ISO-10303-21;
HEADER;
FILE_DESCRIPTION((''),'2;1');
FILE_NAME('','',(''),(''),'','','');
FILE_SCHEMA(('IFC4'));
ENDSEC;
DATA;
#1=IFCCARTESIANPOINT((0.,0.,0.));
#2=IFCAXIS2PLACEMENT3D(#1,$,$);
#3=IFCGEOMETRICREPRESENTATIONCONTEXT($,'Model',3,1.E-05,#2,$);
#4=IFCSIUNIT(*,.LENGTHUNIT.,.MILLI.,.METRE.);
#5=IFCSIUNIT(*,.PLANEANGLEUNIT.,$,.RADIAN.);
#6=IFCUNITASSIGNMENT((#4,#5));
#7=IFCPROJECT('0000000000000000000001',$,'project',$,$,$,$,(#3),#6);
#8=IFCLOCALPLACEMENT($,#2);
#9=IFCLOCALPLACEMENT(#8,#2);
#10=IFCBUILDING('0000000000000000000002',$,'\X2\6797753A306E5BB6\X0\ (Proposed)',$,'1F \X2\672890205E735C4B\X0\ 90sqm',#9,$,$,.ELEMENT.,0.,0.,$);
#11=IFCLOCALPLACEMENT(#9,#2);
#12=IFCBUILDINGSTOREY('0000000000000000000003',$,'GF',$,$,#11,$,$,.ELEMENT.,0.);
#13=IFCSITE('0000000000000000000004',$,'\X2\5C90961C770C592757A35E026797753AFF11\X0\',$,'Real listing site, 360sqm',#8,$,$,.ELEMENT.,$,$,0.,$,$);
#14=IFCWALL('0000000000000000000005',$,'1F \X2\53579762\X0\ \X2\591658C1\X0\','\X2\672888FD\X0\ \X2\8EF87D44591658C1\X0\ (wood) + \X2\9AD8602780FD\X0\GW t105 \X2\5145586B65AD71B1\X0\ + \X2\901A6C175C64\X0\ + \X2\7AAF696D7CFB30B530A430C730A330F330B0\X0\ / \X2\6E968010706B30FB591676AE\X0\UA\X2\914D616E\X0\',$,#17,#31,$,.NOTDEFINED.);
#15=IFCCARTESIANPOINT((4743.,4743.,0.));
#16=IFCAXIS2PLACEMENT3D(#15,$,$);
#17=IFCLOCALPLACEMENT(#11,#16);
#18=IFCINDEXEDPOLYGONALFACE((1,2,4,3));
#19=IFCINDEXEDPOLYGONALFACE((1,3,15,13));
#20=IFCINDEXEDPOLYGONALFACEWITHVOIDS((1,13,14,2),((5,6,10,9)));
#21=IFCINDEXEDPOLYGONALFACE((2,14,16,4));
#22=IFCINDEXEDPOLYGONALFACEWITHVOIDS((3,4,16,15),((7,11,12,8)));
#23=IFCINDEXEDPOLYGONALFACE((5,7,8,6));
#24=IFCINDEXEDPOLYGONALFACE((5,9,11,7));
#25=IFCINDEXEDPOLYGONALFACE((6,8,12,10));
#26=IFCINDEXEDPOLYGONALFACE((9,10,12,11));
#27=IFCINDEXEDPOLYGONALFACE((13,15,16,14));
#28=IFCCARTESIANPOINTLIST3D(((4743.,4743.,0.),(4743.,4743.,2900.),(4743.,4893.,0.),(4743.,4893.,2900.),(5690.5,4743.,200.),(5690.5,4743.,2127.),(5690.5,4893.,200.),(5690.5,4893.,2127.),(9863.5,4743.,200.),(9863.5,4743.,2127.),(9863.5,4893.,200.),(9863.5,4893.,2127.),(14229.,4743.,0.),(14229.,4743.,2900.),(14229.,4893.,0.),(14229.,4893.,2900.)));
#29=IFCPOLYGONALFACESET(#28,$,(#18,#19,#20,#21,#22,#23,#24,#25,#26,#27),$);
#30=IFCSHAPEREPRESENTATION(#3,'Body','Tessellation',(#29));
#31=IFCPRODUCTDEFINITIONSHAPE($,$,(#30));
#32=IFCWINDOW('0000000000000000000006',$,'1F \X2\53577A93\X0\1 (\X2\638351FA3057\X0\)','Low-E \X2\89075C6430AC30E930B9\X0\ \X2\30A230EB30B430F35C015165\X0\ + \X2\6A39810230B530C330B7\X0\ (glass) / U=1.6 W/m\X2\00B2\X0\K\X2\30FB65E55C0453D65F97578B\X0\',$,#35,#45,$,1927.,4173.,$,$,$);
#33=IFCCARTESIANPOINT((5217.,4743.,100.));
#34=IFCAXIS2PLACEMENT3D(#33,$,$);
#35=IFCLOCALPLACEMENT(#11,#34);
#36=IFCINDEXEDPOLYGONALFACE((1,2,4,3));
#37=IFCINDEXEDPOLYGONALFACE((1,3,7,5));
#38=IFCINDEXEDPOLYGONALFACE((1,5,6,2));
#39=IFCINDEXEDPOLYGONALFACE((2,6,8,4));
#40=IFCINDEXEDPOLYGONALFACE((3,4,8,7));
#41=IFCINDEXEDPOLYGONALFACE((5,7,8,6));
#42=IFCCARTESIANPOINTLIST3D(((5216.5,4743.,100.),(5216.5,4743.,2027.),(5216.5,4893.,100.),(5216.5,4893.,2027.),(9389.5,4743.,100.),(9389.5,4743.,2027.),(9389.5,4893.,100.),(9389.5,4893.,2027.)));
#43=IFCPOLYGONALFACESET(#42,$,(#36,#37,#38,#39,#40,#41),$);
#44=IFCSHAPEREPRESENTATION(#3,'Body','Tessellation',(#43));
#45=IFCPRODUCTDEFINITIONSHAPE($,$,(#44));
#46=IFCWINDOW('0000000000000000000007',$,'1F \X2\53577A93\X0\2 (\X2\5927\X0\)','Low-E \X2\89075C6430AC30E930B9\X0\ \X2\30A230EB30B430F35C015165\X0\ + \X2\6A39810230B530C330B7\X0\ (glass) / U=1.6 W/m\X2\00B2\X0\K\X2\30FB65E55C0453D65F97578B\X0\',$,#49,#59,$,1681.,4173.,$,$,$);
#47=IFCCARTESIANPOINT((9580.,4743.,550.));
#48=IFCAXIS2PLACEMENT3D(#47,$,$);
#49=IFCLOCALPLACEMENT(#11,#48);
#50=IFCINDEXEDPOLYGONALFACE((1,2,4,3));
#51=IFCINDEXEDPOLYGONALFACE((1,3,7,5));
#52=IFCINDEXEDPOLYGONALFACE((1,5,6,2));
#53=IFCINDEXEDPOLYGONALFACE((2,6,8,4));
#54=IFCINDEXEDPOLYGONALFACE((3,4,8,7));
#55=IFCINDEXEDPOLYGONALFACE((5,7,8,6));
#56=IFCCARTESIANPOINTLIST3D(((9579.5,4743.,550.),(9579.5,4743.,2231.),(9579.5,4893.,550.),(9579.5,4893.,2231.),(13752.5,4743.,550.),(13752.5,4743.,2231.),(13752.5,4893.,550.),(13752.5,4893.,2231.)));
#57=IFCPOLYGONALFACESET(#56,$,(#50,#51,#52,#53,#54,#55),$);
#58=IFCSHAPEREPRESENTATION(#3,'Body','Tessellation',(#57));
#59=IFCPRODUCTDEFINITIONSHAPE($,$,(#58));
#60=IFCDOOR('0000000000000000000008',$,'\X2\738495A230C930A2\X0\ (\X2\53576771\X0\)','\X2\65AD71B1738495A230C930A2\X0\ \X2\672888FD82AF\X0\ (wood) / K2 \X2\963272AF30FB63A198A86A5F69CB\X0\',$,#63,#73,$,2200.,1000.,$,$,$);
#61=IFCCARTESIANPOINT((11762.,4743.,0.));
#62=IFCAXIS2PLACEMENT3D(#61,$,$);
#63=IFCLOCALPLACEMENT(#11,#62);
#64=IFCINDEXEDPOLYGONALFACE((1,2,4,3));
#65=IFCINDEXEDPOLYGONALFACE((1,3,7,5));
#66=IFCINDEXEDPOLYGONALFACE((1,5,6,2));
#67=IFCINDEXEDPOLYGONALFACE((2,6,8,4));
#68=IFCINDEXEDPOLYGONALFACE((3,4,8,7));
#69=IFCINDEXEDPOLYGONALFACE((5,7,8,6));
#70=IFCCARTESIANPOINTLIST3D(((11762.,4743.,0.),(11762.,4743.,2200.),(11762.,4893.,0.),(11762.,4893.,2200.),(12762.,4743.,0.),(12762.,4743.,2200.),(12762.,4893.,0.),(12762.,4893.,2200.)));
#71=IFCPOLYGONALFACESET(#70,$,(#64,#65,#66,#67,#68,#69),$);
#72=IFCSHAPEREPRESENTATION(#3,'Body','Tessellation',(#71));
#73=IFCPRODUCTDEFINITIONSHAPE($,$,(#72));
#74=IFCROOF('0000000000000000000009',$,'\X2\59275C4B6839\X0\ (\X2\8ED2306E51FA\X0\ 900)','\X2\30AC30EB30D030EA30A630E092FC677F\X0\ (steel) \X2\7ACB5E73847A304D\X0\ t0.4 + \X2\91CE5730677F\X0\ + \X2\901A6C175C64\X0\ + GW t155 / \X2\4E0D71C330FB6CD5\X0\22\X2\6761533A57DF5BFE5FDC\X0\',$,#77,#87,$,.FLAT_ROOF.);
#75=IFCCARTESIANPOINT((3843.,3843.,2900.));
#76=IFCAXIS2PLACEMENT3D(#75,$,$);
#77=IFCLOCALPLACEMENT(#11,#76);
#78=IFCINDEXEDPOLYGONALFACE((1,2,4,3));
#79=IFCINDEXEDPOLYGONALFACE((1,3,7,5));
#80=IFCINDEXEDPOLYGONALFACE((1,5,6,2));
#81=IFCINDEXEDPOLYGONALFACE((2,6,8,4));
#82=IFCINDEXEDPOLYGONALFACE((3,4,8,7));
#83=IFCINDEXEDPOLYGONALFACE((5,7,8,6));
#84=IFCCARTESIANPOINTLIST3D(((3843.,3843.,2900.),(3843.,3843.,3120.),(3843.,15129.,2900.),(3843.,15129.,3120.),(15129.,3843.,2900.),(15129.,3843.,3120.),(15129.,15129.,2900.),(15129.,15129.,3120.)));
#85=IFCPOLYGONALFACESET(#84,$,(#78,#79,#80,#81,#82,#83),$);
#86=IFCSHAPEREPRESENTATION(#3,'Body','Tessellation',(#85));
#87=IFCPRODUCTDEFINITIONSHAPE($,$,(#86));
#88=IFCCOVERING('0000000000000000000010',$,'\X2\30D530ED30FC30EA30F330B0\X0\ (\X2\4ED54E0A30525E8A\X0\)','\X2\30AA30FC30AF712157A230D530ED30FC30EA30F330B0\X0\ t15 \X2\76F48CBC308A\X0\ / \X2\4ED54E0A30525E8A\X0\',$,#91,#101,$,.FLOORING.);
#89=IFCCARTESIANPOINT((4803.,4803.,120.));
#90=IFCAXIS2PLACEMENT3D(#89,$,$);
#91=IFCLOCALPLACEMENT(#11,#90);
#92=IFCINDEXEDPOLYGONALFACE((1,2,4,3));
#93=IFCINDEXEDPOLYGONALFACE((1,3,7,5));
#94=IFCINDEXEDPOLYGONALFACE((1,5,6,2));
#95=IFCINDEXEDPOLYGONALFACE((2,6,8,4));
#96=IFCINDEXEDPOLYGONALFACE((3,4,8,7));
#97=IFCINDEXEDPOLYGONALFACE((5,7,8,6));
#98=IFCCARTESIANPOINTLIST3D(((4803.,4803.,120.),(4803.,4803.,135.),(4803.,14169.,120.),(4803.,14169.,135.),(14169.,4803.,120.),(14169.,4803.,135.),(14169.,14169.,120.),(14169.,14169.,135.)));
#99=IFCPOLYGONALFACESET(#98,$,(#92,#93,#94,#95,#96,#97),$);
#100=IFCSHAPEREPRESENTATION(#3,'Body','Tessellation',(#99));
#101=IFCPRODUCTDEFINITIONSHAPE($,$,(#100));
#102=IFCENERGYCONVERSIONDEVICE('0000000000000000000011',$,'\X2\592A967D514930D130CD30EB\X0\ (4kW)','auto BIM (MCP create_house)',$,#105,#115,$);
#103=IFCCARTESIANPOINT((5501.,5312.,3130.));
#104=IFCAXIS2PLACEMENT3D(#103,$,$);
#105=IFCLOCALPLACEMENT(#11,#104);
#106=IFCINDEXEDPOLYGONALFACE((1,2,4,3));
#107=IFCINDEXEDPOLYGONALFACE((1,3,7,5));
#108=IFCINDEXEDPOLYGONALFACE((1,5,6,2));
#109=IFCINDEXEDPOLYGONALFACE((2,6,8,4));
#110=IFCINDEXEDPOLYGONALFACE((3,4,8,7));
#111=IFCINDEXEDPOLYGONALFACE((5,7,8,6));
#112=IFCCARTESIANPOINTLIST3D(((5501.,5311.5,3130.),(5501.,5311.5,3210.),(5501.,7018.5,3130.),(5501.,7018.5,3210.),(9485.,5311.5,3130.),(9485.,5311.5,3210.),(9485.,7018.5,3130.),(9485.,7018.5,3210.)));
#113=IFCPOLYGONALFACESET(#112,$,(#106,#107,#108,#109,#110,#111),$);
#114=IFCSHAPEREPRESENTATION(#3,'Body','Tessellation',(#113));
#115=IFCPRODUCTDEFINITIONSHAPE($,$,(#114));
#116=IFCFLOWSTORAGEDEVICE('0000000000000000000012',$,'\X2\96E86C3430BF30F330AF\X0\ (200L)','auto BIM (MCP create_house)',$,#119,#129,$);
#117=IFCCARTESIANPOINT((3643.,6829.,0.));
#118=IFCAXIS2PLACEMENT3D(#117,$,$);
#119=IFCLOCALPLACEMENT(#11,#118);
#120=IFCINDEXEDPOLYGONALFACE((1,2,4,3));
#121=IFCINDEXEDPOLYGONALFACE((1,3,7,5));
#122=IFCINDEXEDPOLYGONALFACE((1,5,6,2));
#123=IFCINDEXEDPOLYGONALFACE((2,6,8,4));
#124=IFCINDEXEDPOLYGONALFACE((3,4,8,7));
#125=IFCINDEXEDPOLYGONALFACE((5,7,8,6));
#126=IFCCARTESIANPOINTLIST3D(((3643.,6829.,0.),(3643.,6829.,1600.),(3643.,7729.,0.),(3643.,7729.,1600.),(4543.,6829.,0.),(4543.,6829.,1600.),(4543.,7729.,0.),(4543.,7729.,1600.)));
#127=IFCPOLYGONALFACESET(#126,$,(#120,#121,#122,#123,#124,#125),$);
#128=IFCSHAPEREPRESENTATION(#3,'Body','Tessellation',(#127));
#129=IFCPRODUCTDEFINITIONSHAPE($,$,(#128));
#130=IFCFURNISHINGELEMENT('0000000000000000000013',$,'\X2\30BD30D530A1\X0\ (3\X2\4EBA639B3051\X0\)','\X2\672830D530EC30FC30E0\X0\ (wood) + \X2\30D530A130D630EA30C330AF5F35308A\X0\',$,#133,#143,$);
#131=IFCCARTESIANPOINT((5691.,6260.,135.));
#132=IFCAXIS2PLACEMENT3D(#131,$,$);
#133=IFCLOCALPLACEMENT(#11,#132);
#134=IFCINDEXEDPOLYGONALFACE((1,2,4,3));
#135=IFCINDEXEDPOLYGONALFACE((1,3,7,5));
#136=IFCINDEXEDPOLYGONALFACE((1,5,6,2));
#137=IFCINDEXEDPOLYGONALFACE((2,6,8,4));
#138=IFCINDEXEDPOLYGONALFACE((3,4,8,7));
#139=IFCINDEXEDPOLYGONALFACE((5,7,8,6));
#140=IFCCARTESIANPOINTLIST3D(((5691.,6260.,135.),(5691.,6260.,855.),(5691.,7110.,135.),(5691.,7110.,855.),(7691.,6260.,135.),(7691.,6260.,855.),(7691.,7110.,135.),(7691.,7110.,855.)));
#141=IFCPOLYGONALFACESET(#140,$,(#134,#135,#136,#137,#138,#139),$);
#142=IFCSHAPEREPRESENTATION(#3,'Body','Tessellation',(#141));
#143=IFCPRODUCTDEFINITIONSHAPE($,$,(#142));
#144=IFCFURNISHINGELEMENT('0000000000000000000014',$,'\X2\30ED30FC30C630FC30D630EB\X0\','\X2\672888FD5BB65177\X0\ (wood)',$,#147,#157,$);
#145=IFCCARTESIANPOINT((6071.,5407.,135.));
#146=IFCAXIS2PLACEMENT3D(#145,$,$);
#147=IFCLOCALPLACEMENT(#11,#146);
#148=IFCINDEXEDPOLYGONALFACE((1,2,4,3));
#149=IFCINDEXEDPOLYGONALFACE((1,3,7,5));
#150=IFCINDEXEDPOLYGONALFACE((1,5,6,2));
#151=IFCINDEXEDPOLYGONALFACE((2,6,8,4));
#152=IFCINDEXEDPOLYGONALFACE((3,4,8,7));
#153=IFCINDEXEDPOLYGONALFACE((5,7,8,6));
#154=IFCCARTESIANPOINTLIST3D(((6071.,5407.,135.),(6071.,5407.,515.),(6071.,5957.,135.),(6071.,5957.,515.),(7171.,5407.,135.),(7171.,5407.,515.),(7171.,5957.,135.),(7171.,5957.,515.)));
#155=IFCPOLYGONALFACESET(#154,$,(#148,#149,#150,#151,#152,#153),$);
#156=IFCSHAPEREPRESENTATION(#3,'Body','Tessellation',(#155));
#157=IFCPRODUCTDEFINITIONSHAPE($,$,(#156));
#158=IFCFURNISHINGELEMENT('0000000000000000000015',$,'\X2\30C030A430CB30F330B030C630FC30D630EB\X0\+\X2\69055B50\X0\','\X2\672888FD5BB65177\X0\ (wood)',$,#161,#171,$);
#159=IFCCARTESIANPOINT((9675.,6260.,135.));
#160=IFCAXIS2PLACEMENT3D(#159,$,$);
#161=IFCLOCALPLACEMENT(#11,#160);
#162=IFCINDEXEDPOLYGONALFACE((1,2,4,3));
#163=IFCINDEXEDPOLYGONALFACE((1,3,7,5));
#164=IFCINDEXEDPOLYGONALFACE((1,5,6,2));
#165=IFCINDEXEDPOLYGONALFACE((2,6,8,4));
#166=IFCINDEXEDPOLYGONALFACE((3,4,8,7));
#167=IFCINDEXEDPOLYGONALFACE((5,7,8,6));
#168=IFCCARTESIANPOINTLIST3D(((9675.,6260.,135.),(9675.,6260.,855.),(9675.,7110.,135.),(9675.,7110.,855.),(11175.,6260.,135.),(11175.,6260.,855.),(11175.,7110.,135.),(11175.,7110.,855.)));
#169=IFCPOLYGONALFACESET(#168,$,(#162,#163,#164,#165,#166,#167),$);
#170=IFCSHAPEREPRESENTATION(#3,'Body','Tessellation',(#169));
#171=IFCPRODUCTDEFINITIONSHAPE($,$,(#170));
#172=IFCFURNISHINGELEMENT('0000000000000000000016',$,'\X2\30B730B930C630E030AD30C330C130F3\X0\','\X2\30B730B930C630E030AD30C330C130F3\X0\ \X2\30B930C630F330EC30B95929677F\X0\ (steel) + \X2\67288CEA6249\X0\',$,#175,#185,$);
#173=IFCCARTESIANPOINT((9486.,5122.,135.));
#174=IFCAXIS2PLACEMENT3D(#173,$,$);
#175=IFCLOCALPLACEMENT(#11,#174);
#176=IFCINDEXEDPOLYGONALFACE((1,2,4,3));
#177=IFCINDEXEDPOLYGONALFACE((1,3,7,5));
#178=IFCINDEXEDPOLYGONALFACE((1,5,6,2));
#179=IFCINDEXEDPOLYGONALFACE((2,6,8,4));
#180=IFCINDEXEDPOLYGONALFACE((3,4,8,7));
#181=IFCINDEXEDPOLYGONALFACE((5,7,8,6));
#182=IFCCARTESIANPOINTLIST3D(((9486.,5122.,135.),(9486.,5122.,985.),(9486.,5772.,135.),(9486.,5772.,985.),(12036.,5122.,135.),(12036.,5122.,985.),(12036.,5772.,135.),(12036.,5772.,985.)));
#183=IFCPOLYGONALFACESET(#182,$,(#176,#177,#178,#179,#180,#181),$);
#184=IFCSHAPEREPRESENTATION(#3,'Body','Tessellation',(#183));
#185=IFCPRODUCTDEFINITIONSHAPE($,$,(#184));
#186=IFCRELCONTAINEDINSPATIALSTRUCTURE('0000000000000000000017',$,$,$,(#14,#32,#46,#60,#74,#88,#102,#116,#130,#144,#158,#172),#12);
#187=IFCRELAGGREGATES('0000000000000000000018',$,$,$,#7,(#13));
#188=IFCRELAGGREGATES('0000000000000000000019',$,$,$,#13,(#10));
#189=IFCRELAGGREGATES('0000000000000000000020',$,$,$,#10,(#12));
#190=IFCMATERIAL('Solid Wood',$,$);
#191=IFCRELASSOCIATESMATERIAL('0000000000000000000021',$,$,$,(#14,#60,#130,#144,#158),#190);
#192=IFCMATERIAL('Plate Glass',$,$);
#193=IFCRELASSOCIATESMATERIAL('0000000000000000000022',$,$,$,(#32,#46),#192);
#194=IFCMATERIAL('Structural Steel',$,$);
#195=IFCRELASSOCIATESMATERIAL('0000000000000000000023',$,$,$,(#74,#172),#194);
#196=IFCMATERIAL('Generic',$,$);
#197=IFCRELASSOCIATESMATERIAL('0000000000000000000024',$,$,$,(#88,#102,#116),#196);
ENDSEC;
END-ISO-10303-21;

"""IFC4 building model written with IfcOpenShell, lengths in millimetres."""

from ifc_helpers import new_model, si_unit, frame, frame_2d, origin, place, context, project, spatial, rectangle, extrude, material, element, fill, save


model = new_model("IFC4")

# Units and contexts
model_context = context("Model", 3, precision=1e-05, world=origin())
ifc_project = project(units=[si_unit("LENGTHUNIT", "METRE", prefix="MILLI"), si_unit("PLANEANGLEUNIT", "RADIAN")], contexts=[model_context])

# Site, building, storey
site_placement = place(None, origin())
site = spatial("IfcSite", under=ifc_project, at=site_placement, Name="岐阜県大垣市林町１", ObjectType="Real listing site, 360sqm", CompositionType="ELEMENT", RefElevation=0.0)
building_placement = place(site_placement, origin())
building = spatial("IfcBuilding", under=site, at=building_placement, Name="林町の家 (Proposed)", ObjectType="1F 木造平屋 90sqm", CompositionType="ELEMENT", ElevationOfRefHeight=0.0, ElevationOfTerrain=0.0)
storey_placement = place(building_placement, origin())
storey = spatial("IfcBuildingStorey", under=building, at=storey_placement, Name="GF", CompositionType="ELEMENT", Elevation=0.0)

# Shared definitions
ifc_material_1 = material(Name="Solid Wood")

# Wall, openings, windows, door
wall_1_placement = place(storey_placement, frame((4743.0, 4743.0, 0.0)))
wall_1 = element("IfcWall", 1, at=wall_1_placement, inside=storey, material=ifc_material_1, Name="1F 南面 外壁", Description="木製 軸組外壁 (wood) + 高性能GW t105 充填断熱 + 通気層 + 窯業系サイディング / 準耐火・外皮UA配慮", PredefinedType="NOTDEFINED", context=model_context, shape_type="SweptSolid", body=[
    extrude(rectangle(XDim=9486.0, YDim=150.0, at=frame_2d((4743.0, 75.0))), frame((4743.0, 4743.0, 0.0)), (0.0, 0.0, 1.0), 2900.0),
])
opening_1_placement = place(storey_placement, frame((5217.0, 4743.0, 100.0)))
opening_1 = element("IfcOpeningElement", 2, at=opening_1_placement, cuts=wall_1, PredefinedType="NOTDEFINED", context=model_context, shape_type="SweptSolid", body=[
    extrude(rectangle(XDim=4173.0, YDim=150.0, at=frame_2d((2086.0, 75.0))), frame((5217.0, 4743.0, 100.0)), (0.0, 0.0, 1.0), 1927.0),
])
opening_2_placement = place(storey_placement, frame((9580.0, 4743.0, 550.0)))
opening_2 = element("IfcOpeningElement", 3, at=opening_2_placement, cuts=wall_1, PredefinedType="NOTDEFINED", context=model_context, shape_type="SweptSolid", body=[
    extrude(rectangle(XDim=4173.0, YDim=150.0, at=frame_2d((2086.0, 75.0))), frame((9580.0, 4743.0, 550.0)), (0.0, 0.0, 1.0), 1681.0),
])
opening_3_placement = place(storey_placement, frame((11762.0, 4743.0, 0.0)))
opening_3 = element("IfcOpeningElement", 4, at=opening_3_placement, cuts=wall_1, PredefinedType="NOTDEFINED", context=model_context, shape_type="SweptSolid", body=[
    extrude(rectangle(XDim=1000.0, YDim=150.0, at=frame_2d((500.0, 75.0))), frame((11762.0, 4743.0, 0.0)), (0.0, 0.0, 1.0), 2200.0),
])
ifc_material_2 = material(Name="Plate Glass")
window_1_placement = place(storey_placement, frame((5217.0, 4743.0, 100.0)))
window_1 = element("IfcWindow", 5, at=window_1_placement, inside=storey, material=ifc_material_2, Name="1F 南窓1 (掃出し)", Description="Low-E 複層ガラス アルゴン封入 + 樹脂サッシ (glass) / U=1.6 W/m²K・日射取得型", OverallHeight=1927.0, OverallWidth=4173.0, context=model_context, shape_type="SweptSolid", body=[
    extrude(rectangle(XDim=4173.0, YDim=150.0, at=frame_2d((2086.0, 75.0))), frame((5217.0, 4743.0, 100.0)), (0.0, 0.0, 1.0), 1927.0),
])
fill(opening_1, window_1)
window_2_placement = place(storey_placement, frame((9580.0, 4743.0, 550.0)))
window_2 = element("IfcWindow", 6, at=window_2_placement, inside=storey, material=ifc_material_2, Name="1F 南窓2 (大)", Description="Low-E 複層ガラス アルゴン封入 + 樹脂サッシ (glass) / U=1.6 W/m²K・日射取得型", OverallHeight=1681.0, OverallWidth=4173.0, context=model_context, shape_type="SweptSolid", body=[
    extrude(rectangle(XDim=4173.0, YDim=150.0, at=frame_2d((2086.0, 75.0))), frame((9580.0, 4743.0, 550.0)), (0.0, 0.0, 1.0), 1681.0),
])
fill(opening_2, window_2)
door_placement = place(storey_placement, frame((11762.0, 4743.0, 0.0)))
door = element("IfcDoor", 7, at=door_placement, inside=storey, material=ifc_material_1, Name="玄関ドア (南東)", Description="断熱玄関ドア 木製芯 (wood) / K2 防犯・採風機構", OverallHeight=2200.0, OverallWidth=1000.0, context=model_context, shape_type="SweptSolid", body=[
    extrude(rectangle(XDim=1000.0, YDim=150.0, at=frame_2d((500.0, 75.0))), frame((11762.0, 4743.0, 0.0)), (0.0, 0.0, 1.0), 2200.0),
])
fill(opening_3, door)

# Roof
ifc_material_3 = material(Name="Structural Steel")
roof_placement = place(storey_placement, frame((3843.0, 3843.0, 2900.0)))
element("IfcRoof", 8, at=roof_placement, inside=storey, material=ifc_material_3, Name="大屋根 (軒の出 900)", Description="ガルバリウム鋼板 (steel) 立平葺き t0.4 + 野地板 + 通気層 + GW t155 / 不燃・法22条区域対応", PredefinedType="FLAT_ROOF", context=model_context, shape_type="SweptSolid", body=[
    extrude(rectangle(XDim=11286.0, YDim=11286.0, at=frame_2d((5643.0, 5643.0))), frame((3843.0, 3843.0, 2900.0)), (0.0, 0.0, 1.0), 220.0),
])

# Covering
ifc_material_4 = material(Name="Generic")
covering_placement = place(storey_placement, frame((4803.0, 4803.0, 120.0)))
element("IfcCovering", 9, at=covering_placement, inside=storey, material=ifc_material_4, Name="フローリング (仕上げ床)", Description="オーク無垢フローリング t15 直貼り / 仕上げ床", PredefinedType="FLOORING", context=model_context, shape_type="SweptSolid", body=[
    extrude(rectangle(XDim=9366.0, YDim=9366.0, at=frame_2d((4683.0, 4683.0))), frame((4803.0, 4803.0, 120.0)), (0.0, 0.0, 1.0), 15.0),
])

# Energy conversion device
energy_conversion_device_placement = place(storey_placement, frame((5501.0, 5312.0, 3130.0)))
element("IfcEnergyConversionDevice", 10, at=energy_conversion_device_placement, inside=storey, material=ifc_material_4, Name="太陽光パネル (4kW)", Description="auto BIM (MCP create_house)", context=model_context, shape_type="SweptSolid", body=[
    extrude(rectangle(XDim=3984.0, YDim=1707.0, at=frame_2d((1992.0, 853.0))), frame((5501.0, 5312.0, 3130.0)), (0.0, 0.0, 1.0), 80.0),
])

# Flow storage device
flow_storage_device_placement = place(storey_placement, frame((3643.0, 6829.0, 0.0)))
element("IfcFlowStorageDevice", 11, at=flow_storage_device_placement, inside=storey, material=ifc_material_4, Name="雨水タンク (200L)", Description="auto BIM (MCP create_house)", context=model_context, shape_type="SweptSolid", body=[
    extrude(rectangle(XDim=900.0, YDim=900.0, at=frame_2d((450.0, 450.0))), frame((3643.0, 6829.0, 0.0)), (0.0, 0.0, 1.0), 1600.0),
])

# Furnishing elements
furnishing_1_placement = place(storey_placement, frame((5691.0, 6260.0, 135.0)))
element("IfcFurnishingElement", 12, at=furnishing_1_placement, inside=storey, material=ifc_material_1, Name="ソファ (3人掛け)", Description="木フレーム (wood) + ファブリック張り", context=model_context, shape_type="SweptSolid", body=[
    extrude(rectangle(XDim=2000.0, YDim=850.0, at=frame_2d((1000.0, 425.0))), frame((5691.0, 6260.0, 135.0)), (0.0, 0.0, 1.0), 720.0),
])
furnishing_2_placement = place(storey_placement, frame((6071.0, 5407.0, 135.0)))
element("IfcFurnishingElement", 13, at=furnishing_2_placement, inside=storey, material=ifc_material_1, Name="ローテーブル", Description="木製家具 (wood)", context=model_context, shape_type="SweptSolid", body=[
    extrude(rectangle(XDim=1100.0, YDim=550.0, at=frame_2d((550.0, 275.0))), frame((6071.0, 5407.0, 135.0)), (0.0, 0.0, 1.0), 380.0),
])
furnishing_3_placement = place(storey_placement, frame((9675.0, 6260.0, 135.0)))
element("IfcFurnishingElement", 14, at=furnishing_3_placement, inside=storey, material=ifc_material_1, Name="ダイニングテーブル+椅子", Description="木製家具 (wood)", context=model_context, shape_type="SweptSolid", body=[
    extrude(rectangle(XDim=1500.0, YDim=850.0, at=frame_2d((750.0, 425.0))), frame((9675.0, 6260.0, 135.0)), (0.0, 0.0, 1.0), 720.0),
])
furnishing_4_placement = place(storey_placement, frame((9486.0, 5122.0, 135.0)))
element("IfcFurnishingElement", 15, at=furnishing_4_placement, inside=storey, material=ifc_material_3, Name="システムキッチン", Description="システムキッチン ステンレス天板 (steel) + 木質扉", context=model_context, shape_type="SweptSolid", body=[
    extrude(rectangle(XDim=2550.0, YDim=650.0, at=frame_2d((1275.0, 325.0))), frame((9486.0, 5122.0, 135.0)), (0.0, 0.0, 1.0), 850.0),
])

save(model, "model.ifc")
